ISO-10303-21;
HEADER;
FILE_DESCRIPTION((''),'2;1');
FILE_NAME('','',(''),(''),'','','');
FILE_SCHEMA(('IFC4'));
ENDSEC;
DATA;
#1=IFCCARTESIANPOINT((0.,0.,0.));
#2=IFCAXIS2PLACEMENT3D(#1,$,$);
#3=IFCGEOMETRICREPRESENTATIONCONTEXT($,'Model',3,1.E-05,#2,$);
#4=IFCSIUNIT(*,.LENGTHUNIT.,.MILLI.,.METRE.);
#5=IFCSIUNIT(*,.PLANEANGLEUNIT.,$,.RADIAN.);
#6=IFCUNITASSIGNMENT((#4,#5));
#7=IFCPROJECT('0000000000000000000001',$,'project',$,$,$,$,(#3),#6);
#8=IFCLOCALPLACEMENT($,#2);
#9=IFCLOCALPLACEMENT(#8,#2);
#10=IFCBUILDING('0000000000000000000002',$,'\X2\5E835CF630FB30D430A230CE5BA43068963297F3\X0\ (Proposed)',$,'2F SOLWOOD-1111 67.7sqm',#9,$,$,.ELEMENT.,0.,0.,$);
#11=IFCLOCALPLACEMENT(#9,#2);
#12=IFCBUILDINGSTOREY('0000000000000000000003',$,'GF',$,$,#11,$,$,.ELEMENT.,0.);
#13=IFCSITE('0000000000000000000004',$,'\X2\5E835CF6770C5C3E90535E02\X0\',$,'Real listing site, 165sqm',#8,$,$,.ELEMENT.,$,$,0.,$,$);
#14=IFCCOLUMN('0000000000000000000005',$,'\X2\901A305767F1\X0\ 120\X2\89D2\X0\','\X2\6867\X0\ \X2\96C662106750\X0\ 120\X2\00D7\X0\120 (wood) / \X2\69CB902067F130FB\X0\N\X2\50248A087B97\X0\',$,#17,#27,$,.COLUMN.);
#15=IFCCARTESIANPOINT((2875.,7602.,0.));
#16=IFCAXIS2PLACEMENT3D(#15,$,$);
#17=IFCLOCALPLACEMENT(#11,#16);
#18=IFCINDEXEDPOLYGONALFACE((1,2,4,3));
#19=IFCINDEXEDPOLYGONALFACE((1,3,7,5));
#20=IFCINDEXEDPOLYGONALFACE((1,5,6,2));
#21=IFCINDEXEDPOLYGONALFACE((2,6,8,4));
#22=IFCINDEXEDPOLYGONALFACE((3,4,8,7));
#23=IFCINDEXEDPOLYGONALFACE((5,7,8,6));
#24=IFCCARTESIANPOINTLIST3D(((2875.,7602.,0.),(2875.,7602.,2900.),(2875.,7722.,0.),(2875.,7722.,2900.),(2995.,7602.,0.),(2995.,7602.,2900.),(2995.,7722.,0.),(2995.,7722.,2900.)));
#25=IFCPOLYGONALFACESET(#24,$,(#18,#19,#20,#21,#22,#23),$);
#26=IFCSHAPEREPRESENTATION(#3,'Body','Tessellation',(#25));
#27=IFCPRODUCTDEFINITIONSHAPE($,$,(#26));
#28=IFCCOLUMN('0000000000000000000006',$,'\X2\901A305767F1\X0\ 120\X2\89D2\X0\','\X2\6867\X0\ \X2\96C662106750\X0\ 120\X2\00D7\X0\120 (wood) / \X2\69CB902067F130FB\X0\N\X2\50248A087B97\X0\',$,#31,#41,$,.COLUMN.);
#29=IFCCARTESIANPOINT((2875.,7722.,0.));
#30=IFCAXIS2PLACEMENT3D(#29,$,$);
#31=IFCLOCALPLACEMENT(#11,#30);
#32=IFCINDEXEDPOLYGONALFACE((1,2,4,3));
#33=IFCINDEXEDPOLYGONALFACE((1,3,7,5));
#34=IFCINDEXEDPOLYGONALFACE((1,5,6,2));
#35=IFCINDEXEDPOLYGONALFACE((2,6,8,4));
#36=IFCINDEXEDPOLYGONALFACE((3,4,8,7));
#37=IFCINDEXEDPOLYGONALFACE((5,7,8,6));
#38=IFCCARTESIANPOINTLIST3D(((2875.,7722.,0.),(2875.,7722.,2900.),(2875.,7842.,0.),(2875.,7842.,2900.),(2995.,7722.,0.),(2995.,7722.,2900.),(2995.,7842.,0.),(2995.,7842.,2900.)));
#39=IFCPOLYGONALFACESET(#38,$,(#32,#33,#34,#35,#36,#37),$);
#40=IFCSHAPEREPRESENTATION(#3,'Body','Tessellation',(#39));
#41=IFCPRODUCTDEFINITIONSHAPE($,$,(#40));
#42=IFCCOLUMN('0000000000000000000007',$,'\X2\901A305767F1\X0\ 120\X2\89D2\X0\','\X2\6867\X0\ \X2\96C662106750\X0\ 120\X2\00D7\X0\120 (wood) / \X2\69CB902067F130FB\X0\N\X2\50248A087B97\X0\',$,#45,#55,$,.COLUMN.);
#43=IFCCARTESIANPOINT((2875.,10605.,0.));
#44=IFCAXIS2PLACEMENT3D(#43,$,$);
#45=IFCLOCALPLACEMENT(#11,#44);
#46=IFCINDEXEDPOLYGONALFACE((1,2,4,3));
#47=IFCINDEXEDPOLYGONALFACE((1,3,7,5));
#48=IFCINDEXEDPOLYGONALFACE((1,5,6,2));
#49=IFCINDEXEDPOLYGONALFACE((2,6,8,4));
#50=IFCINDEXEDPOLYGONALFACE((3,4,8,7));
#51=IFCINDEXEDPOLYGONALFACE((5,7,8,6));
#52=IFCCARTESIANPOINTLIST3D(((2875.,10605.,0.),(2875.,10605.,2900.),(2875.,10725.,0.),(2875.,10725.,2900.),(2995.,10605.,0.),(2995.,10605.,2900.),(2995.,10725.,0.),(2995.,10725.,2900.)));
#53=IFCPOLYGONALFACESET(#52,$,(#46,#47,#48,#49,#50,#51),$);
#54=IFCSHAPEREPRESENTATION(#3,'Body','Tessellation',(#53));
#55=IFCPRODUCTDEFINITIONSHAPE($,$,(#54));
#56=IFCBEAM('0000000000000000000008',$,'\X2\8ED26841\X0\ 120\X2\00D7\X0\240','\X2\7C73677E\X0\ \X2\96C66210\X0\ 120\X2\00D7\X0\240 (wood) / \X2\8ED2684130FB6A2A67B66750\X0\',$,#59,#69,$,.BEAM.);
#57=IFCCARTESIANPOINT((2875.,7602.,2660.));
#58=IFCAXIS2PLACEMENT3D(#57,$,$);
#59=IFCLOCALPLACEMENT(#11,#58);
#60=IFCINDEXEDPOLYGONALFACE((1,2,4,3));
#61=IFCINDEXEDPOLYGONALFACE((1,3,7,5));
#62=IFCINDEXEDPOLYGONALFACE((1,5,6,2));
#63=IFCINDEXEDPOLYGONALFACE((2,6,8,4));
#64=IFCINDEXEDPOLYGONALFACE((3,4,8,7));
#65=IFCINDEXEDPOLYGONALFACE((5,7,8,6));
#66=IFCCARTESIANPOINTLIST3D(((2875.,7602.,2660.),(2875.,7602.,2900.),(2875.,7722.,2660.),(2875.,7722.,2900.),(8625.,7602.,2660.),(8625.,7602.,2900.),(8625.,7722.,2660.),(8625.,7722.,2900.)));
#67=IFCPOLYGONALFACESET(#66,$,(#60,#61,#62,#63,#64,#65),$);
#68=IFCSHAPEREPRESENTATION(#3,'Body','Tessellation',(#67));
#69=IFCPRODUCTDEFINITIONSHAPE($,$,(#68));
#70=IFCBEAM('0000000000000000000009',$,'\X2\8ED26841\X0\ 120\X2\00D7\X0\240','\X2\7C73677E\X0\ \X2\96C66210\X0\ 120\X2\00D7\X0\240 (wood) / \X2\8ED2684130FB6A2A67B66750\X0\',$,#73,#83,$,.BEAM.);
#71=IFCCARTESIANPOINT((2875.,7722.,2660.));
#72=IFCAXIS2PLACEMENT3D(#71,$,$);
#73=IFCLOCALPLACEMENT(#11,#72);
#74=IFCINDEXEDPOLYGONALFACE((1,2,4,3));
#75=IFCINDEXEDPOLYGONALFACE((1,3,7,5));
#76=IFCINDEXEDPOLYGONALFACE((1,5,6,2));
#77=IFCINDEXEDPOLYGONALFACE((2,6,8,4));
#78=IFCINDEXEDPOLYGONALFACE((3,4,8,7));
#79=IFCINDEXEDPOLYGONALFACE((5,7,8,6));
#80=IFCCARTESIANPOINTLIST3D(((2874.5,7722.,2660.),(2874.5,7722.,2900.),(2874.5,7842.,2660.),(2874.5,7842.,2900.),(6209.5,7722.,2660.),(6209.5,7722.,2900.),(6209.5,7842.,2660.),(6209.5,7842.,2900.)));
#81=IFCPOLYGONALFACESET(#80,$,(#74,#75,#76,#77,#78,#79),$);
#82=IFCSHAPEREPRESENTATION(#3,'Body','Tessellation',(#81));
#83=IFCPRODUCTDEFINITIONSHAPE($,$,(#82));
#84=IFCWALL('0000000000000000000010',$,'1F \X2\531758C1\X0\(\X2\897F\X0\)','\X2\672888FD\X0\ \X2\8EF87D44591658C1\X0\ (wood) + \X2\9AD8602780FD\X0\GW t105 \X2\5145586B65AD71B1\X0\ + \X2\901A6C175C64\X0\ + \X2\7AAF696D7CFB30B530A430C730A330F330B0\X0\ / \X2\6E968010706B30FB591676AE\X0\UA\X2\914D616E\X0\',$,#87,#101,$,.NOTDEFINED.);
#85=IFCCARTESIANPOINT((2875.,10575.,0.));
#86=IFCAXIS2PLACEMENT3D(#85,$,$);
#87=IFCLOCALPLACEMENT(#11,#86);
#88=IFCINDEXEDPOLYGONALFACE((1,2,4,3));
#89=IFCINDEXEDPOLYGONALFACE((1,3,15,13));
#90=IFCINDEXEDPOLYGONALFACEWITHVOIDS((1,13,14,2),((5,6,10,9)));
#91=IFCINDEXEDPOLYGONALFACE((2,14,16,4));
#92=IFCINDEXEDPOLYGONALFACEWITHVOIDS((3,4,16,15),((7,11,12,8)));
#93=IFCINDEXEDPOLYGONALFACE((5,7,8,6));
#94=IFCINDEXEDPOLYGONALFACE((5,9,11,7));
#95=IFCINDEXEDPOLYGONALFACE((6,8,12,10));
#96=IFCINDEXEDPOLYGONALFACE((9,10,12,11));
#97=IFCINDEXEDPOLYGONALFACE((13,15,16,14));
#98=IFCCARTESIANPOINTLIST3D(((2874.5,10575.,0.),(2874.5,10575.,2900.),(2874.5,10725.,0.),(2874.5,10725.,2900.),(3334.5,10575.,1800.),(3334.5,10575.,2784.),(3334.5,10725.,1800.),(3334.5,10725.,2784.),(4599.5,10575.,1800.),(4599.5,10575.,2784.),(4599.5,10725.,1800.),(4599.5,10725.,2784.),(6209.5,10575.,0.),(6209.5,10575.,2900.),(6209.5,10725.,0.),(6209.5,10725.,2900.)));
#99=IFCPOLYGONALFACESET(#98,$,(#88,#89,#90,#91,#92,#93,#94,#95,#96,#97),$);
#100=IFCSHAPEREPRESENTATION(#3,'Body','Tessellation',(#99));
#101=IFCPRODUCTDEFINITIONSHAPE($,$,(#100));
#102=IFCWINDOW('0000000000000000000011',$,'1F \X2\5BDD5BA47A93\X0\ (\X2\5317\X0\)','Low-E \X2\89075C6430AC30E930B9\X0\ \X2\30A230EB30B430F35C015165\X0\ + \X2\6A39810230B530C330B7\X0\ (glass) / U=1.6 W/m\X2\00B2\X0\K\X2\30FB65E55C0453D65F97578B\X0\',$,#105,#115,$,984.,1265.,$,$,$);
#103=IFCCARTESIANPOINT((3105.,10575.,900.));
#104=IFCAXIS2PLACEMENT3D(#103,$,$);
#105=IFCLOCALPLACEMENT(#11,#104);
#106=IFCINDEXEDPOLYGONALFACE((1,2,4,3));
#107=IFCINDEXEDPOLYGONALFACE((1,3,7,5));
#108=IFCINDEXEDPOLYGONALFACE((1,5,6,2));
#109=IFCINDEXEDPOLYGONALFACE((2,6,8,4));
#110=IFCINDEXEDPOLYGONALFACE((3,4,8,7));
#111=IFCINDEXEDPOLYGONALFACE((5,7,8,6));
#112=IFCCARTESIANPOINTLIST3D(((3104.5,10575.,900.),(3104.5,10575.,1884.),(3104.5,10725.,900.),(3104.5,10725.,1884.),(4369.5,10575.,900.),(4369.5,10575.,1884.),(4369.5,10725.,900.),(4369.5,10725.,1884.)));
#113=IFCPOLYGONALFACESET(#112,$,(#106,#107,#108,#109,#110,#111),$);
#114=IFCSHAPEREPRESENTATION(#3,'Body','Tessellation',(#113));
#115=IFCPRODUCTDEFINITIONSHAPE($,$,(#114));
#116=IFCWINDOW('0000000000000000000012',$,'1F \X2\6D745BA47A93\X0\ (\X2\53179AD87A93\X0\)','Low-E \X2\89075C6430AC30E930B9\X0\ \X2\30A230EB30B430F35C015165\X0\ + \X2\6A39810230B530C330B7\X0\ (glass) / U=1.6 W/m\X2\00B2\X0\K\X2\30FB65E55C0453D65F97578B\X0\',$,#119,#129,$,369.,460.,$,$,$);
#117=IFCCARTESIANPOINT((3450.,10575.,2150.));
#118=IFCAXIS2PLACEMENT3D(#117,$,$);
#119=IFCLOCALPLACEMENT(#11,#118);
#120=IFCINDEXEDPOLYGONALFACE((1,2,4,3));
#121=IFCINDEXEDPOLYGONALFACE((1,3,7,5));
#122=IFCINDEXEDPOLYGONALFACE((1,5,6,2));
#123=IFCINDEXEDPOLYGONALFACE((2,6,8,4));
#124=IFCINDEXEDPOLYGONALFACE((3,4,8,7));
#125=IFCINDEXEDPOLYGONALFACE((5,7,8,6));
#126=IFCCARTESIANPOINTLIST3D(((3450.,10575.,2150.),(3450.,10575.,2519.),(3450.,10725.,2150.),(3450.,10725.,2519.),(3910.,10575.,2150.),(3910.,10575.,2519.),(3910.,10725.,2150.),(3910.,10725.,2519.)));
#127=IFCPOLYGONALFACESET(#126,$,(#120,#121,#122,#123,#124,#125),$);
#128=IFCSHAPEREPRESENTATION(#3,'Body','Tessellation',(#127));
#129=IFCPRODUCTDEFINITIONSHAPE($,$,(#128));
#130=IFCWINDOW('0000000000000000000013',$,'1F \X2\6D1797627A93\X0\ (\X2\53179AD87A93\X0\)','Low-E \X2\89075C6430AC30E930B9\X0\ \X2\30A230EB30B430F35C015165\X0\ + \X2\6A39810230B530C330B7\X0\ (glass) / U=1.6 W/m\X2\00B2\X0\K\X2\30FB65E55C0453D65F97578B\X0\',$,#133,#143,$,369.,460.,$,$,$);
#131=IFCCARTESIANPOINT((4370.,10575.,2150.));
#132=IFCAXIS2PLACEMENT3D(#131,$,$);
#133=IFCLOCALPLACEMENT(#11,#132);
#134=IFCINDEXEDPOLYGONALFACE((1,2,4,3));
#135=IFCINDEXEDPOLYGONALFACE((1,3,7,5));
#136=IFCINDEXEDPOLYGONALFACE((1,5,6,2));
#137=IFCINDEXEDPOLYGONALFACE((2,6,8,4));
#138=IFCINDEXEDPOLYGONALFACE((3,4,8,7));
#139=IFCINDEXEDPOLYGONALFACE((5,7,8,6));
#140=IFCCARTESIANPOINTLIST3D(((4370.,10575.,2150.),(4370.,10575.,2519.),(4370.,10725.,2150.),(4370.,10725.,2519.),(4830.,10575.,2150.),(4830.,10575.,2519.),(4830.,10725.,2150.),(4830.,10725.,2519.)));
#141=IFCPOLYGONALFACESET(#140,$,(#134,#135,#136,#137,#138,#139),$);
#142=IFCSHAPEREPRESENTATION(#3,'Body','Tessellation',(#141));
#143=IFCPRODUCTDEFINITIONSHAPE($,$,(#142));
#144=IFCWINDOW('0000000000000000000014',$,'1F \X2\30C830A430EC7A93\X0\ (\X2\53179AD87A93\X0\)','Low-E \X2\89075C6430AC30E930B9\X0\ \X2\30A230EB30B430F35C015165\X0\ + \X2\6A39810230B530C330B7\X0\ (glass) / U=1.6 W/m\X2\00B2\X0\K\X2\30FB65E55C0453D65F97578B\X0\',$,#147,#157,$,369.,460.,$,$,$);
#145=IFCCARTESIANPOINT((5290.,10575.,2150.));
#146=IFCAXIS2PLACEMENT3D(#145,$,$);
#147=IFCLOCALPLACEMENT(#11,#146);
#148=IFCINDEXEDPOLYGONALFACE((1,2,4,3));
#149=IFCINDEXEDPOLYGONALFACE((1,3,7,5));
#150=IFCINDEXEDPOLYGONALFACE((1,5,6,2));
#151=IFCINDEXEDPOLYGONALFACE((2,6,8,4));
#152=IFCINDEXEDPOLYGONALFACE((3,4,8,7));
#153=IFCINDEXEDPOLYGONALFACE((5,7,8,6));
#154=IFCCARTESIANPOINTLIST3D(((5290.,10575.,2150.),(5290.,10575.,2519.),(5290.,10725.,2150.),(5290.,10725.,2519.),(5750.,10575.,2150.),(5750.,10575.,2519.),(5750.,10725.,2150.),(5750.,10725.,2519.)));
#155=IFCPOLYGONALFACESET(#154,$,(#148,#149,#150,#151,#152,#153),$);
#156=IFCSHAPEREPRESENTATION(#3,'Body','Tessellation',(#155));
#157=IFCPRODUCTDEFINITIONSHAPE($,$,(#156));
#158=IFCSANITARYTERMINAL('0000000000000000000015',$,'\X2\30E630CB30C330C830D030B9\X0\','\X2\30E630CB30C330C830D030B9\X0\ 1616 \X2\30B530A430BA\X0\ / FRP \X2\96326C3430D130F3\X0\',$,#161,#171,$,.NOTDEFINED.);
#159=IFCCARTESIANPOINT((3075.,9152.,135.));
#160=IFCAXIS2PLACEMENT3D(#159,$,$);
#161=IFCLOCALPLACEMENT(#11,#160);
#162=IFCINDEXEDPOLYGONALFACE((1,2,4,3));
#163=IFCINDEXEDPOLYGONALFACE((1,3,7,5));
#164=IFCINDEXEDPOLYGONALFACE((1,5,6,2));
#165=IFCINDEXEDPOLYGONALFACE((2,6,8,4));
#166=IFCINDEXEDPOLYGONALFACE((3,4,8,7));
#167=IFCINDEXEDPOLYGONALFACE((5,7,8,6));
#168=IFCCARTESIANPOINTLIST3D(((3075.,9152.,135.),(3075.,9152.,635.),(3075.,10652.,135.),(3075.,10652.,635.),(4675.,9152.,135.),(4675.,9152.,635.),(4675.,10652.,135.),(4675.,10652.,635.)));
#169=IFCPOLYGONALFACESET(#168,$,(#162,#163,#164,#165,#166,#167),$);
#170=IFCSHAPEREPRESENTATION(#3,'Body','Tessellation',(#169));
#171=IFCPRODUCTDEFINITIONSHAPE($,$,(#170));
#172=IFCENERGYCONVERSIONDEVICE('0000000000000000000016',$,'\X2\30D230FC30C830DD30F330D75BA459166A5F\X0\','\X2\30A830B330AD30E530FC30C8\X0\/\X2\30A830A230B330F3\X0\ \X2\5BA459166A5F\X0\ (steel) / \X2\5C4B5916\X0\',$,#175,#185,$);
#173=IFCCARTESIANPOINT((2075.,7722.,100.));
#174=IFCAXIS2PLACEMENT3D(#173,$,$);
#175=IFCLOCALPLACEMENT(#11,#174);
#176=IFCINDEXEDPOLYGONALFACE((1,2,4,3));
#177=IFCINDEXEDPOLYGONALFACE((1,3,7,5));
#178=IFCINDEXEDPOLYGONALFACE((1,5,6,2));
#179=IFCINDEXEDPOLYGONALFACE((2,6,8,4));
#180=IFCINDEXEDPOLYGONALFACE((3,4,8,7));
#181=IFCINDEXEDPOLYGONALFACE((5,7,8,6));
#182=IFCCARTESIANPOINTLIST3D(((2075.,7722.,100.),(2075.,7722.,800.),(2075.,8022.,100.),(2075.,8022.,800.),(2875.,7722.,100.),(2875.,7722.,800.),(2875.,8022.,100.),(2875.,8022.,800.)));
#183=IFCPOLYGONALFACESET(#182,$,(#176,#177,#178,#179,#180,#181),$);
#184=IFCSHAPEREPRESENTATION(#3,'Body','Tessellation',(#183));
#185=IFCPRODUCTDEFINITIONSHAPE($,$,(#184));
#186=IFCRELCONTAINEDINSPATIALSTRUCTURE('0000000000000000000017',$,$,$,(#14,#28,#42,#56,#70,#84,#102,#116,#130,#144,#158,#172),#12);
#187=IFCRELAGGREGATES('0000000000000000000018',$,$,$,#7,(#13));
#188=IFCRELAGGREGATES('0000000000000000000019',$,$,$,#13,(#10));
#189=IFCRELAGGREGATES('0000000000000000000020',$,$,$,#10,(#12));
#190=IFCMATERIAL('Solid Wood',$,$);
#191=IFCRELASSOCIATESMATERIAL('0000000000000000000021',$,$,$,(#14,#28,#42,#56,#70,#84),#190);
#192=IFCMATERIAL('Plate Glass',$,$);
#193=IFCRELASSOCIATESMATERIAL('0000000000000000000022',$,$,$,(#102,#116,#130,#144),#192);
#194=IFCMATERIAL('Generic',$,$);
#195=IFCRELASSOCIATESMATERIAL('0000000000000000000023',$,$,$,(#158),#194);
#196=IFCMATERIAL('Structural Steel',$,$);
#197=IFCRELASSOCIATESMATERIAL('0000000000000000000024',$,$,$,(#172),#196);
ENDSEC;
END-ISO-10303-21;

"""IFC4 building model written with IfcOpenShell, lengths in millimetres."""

from ifc_helpers import new_model, si_unit, frame, frame_2d, origin, place, context, project, spatial, rectangle, extrude, material, element, fill, save


model = new_model("IFC4")

# Units and contexts
model_context = context("Model", 3, precision=1e-05, world=origin())
ifc_project = project(units=[si_unit("LENGTHUNIT", "METRE", prefix="MILLI"), si_unit("PLANEANGLEUNIT", "RADIAN")], contexts=[model_context])

# Site, building, storey
site_placement = place(None, origin())
site = spatial("IfcSite", under=ifc_project, at=site_placement, Name="広島県尾道市", ObjectType="Real listing site, 165sqm", CompositionType="ELEMENT", RefElevation=0.0)
building_placement = place(site_placement, origin())
building = spatial("IfcBuilding", under=site, at=building_placement, Name="広島・ピアノ室と防音 (Proposed)", ObjectType="2F SOLWOOD-1111 67.7sqm", CompositionType="ELEMENT", ElevationOfRefHeight=0.0, ElevationOfTerrain=0.0)
storey_placement = place(building_placement, origin())
storey = spatial("IfcBuildingStorey", under=building, at=storey_placement, Name="GF", CompositionType="ELEMENT", Elevation=0.0)

# Columns
ifc_material_1 = material(Name="Solid Wood")
column_1_placement = place(storey_placement, frame((2875.0, 7602.0, 0.0)))
element("IfcColumn", 1, at=column_1_placement, inside=storey, material=ifc_material_1, Name="通し柱 120角", Description="桧 集成材 120×120 (wood) / 構造柱・N値計算", PredefinedType="COLUMN", context=model_context, shape_type="SweptSolid", body=[
    extrude(rectangle(XDim=120.0, YDim=120.0, at=frame_2d((60.0, 60.0))), frame((2875.0, 7602.0, 0.0)), (0.0, 0.0, 1.0), 2900.0),
])
column_2_placement = place(storey_placement, frame((2875.0, 7722.0, 0.0)))
element("IfcColumn", 2, at=column_2_placement, inside=storey, material=ifc_material_1, Name="通し柱 120角", Description="桧 集成材 120×120 (wood) / 構造柱・N値計算", PredefinedType="COLUMN", context=model_context, shape_type="SweptSolid", body=[
    extrude(rectangle(XDim=120.0, YDim=120.0, at=frame_2d((60.0, 60.0))), frame((2875.0, 7722.0, 0.0)), (0.0, 0.0, 1.0), 2900.0),
])
column_3_placement = place(storey_placement, frame((2875.0, 10605.0, 0.0)))
element("IfcColumn", 3, at=column_3_placement, inside=storey, material=ifc_material_1, Name="通し柱 120角", Description="桧 集成材 120×120 (wood) / 構造柱・N値計算", PredefinedType="COLUMN", context=model_context, shape_type="SweptSolid", body=[
    extrude(rectangle(XDim=120.0, YDim=120.0, at=frame_2d((60.0, 60.0))), frame((2875.0, 10605.0, 0.0)), (0.0, 0.0, 1.0), 2900.0),
])

# Beams
beam_1_placement = place(storey_placement, frame((2875.0, 7602.0, 2660.0)))
element("IfcBeam", 4, at=beam_1_placement, inside=storey, material=ifc_material_1, Name="軒桁 120×240", Description="米松 集成 120×240 (wood) / 軒桁・横架材", PredefinedType="BEAM", context=model_context, shape_type="SweptSolid", body=[
    extrude(rectangle(XDim=5750.0, YDim=120.0, at=frame_2d((2875.0, 60.0))), frame((2875.0, 7602.0, 2660.0)), (0.0, 0.0, 1.0), 240.0),
])
beam_2_placement = place(storey_placement, frame((2875.0, 7722.0, 2660.0)))
element("IfcBeam", 5, at=beam_2_placement, inside=storey, material=ifc_material_1, Name="軒桁 120×240", Description="米松 集成 120×240 (wood) / 軒桁・横架材", PredefinedType="BEAM", context=model_context, shape_type="SweptSolid", body=[
    extrude(rectangle(XDim=3335.0, YDim=120.0, at=frame_2d((1667.0, 60.0))), frame((2875.0, 7722.0, 2660.0)), (0.0, 0.0, 1.0), 240.0),
])

# Wall, openings, windows
wall_1_placement = place(storey_placement, frame((2875.0, 10575.0, 0.0)))
wall_1 = element("IfcWall", 6, at=wall_1_placement, inside=storey, material=ifc_material_1, Name="1F 北壁(西)", Description="木製 軸組外壁 (wood) + 高性能GW t105 充填断熱 + 通気層 + 窯業系サイディング / 準耐火・外皮UA配慮", PredefinedType="NOTDEFINED", context=model_context, shape_type="SweptSolid", body=[
    extrude(rectangle(XDim=3335.0, YDim=150.0, at=frame_2d((1667.0, 75.0))), frame((2875.0, 10575.0, 0.0)), (0.0, 0.0, 1.0), 2900.0),
])
opening_1_placement = place(storey_placement, frame((3105.0, 10575.0, 900.0)))
opening_1 = element("IfcOpeningElement", 7, at=opening_1_placement, cuts=wall_1, PredefinedType="NOTDEFINED", context=model_context, shape_type="SweptSolid", body=[
    extrude(rectangle(XDim=1265.0, YDim=150.0, at=frame_2d((632.0, 75.0))), frame((3105.0, 10575.0, 900.0)), (0.0, 0.0, 1.0), 984.0),
])
opening_2_placement = place(storey_placement, frame((3450.0, 10575.0, 2150.0)))
opening_2 = element("IfcOpeningElement", 8, at=opening_2_placement, cuts=wall_1, PredefinedType="NOTDEFINED", context=model_context, shape_type="SweptSolid", body=[
    extrude(rectangle(XDim=460.0, YDim=150.0, at=frame_2d((230.0, 75.0))), frame((3450.0, 10575.0, 2150.0)), (0.0, 0.0, 1.0), 369.0),
])
opening_3_placement = place(storey_placement, frame((4370.0, 10575.0, 2150.0)))
opening_3 = element("IfcOpeningElement", 9, at=opening_3_placement, cuts=wall_1, PredefinedType="NOTDEFINED", context=model_context, shape_type="SweptSolid", body=[
    extrude(rectangle(XDim=460.0, YDim=150.0, at=frame_2d((230.0, 75.0))), frame((4370.0, 10575.0, 2150.0)), (0.0, 0.0, 1.0), 369.0),
])
opening_4_placement = place(storey_placement, frame((5290.0, 10575.0, 2150.0)))
opening_4 = element("IfcOpeningElement", 10, at=opening_4_placement, cuts=wall_1, PredefinedType="NOTDEFINED", context=model_context, shape_type="SweptSolid", body=[
    extrude(rectangle(XDim=460.0, YDim=150.0, at=frame_2d((230.0, 75.0))), frame((5290.0, 10575.0, 2150.0)), (0.0, 0.0, 1.0), 369.0),
])
ifc_material_2 = material(Name="Plate Glass")
window_1_placement = place(storey_placement, frame((3105.0, 10575.0, 900.0)))
window_1 = element("IfcWindow", 11, at=window_1_placement, inside=storey, material=ifc_material_2, Name="1F 寝室窓 (北)", Description="Low-E 複層ガラス アルゴン封入 + 樹脂サッシ (glass) / U=1.6 W/m²K・日射取得型", OverallHeight=984.0, OverallWidth=1265.0, context=model_context, shape_type="SweptSolid", body=[
    extrude(rectangle(XDim=1265.0, YDim=150.0, at=frame_2d((632.0, 75.0))), frame((3105.0, 10575.0, 900.0)), (0.0, 0.0, 1.0), 984.0),
])
fill(opening_1, window_1)
window_2_placement = place(storey_placement, frame((3450.0, 10575.0, 2150.0)))
window_2 = element("IfcWindow", 12, at=window_2_placement, inside=storey, material=ifc_material_2, Name="1F 浴室窓 (北高窓)", Description="Low-E 複層ガラス アルゴン封入 + 樹脂サッシ (glass) / U=1.6 W/m²K・日射取得型", OverallHeight=369.0, OverallWidth=460.0, context=model_context, shape_type="SweptSolid", body=[
    extrude(rectangle(XDim=460.0, YDim=150.0, at=frame_2d((230.0, 75.0))), frame((3450.0, 10575.0, 2150.0)), (0.0, 0.0, 1.0), 369.0),
])
fill(opening_2, window_2)
window_3_placement = place(storey_placement, frame((4370.0, 10575.0, 2150.0)))
window_3 = element("IfcWindow", 13, at=window_3_placement, inside=storey, material=ifc_material_2, Name="1F 洗面窓 (北高窓)", Description="Low-E 複層ガラス アルゴン封入 + 樹脂サッシ (glass) / U=1.6 W/m²K・日射取得型", OverallHeight=369.0, OverallWidth=460.0, context=model_context, shape_type="SweptSolid", body=[
    extrude(rectangle(XDim=460.0, YDim=150.0, at=frame_2d((230.0, 75.0))), frame((4370.0, 10575.0, 2150.0)), (0.0, 0.0, 1.0), 369.0),
])
fill(opening_3, window_3)
window_4_placement = place(storey_placement, frame((5290.0, 10575.0, 2150.0)))
window_4 = element("IfcWindow", 14, at=window_4_placement, inside=storey, material=ifc_material_2, Name="1F トイレ窓 (北高窓)", Description="Low-E 複層ガラス アルゴン封入 + 樹脂サッシ (glass) / U=1.6 W/m²K・日射取得型", OverallHeight=369.0, OverallWidth=460.0, context=model_context, shape_type="SweptSolid", body=[
    extrude(rectangle(XDim=460.0, YDim=150.0, at=frame_2d((230.0, 75.0))), frame((5290.0, 10575.0, 2150.0)), (0.0, 0.0, 1.0), 369.0),
])
fill(opening_4, window_4)

# Shared definitions
ifc_material_3 = material(Name="Generic")

# Sanitary terminal
sanitary_terminal_placement = place(storey_placement, frame((3075.0, 9152.0, 135.0)))
element("IfcSanitaryTerminal", 15, at=sanitary_terminal_placement, inside=storey, material=ifc_material_3, Name="ユニットバス", Description="ユニットバス 1616 サイズ / FRP 防水パン", PredefinedType="NOTDEFINED", context=model_context, shape_type="SweptSolid", body=[
    extrude(rectangle(XDim=1600.0, YDim=1500.0, at=frame_2d((800.0, 750.0))), frame((3075.0, 9152.0, 135.0)), (0.0, 0.0, 1.0), 500.0),
])

# Energy conversion device
ifc_material_4 = material(Name="Structural Steel")
energy_conversion_device_placement = place(storey_placement, frame((2075.0, 7722.0, 100.0)))
element("IfcEnergyConversionDevice", 16, at=energy_conversion_device_placement, inside=storey, material=ifc_material_4, Name="ヒートポンプ室外機", Description="エコキュート/エアコン 室外機 (steel) / 屋外", context=model_context, shape_type="SweptSolid", body=[
    extrude(rectangle(XDim=800.0, YDim=300.0, at=frame_2d((400.0, 150.0))), frame((2075.0, 7722.0, 100.0)), (0.0, 0.0, 1.0), 700.0),
])

save(model, "model.ifc")
